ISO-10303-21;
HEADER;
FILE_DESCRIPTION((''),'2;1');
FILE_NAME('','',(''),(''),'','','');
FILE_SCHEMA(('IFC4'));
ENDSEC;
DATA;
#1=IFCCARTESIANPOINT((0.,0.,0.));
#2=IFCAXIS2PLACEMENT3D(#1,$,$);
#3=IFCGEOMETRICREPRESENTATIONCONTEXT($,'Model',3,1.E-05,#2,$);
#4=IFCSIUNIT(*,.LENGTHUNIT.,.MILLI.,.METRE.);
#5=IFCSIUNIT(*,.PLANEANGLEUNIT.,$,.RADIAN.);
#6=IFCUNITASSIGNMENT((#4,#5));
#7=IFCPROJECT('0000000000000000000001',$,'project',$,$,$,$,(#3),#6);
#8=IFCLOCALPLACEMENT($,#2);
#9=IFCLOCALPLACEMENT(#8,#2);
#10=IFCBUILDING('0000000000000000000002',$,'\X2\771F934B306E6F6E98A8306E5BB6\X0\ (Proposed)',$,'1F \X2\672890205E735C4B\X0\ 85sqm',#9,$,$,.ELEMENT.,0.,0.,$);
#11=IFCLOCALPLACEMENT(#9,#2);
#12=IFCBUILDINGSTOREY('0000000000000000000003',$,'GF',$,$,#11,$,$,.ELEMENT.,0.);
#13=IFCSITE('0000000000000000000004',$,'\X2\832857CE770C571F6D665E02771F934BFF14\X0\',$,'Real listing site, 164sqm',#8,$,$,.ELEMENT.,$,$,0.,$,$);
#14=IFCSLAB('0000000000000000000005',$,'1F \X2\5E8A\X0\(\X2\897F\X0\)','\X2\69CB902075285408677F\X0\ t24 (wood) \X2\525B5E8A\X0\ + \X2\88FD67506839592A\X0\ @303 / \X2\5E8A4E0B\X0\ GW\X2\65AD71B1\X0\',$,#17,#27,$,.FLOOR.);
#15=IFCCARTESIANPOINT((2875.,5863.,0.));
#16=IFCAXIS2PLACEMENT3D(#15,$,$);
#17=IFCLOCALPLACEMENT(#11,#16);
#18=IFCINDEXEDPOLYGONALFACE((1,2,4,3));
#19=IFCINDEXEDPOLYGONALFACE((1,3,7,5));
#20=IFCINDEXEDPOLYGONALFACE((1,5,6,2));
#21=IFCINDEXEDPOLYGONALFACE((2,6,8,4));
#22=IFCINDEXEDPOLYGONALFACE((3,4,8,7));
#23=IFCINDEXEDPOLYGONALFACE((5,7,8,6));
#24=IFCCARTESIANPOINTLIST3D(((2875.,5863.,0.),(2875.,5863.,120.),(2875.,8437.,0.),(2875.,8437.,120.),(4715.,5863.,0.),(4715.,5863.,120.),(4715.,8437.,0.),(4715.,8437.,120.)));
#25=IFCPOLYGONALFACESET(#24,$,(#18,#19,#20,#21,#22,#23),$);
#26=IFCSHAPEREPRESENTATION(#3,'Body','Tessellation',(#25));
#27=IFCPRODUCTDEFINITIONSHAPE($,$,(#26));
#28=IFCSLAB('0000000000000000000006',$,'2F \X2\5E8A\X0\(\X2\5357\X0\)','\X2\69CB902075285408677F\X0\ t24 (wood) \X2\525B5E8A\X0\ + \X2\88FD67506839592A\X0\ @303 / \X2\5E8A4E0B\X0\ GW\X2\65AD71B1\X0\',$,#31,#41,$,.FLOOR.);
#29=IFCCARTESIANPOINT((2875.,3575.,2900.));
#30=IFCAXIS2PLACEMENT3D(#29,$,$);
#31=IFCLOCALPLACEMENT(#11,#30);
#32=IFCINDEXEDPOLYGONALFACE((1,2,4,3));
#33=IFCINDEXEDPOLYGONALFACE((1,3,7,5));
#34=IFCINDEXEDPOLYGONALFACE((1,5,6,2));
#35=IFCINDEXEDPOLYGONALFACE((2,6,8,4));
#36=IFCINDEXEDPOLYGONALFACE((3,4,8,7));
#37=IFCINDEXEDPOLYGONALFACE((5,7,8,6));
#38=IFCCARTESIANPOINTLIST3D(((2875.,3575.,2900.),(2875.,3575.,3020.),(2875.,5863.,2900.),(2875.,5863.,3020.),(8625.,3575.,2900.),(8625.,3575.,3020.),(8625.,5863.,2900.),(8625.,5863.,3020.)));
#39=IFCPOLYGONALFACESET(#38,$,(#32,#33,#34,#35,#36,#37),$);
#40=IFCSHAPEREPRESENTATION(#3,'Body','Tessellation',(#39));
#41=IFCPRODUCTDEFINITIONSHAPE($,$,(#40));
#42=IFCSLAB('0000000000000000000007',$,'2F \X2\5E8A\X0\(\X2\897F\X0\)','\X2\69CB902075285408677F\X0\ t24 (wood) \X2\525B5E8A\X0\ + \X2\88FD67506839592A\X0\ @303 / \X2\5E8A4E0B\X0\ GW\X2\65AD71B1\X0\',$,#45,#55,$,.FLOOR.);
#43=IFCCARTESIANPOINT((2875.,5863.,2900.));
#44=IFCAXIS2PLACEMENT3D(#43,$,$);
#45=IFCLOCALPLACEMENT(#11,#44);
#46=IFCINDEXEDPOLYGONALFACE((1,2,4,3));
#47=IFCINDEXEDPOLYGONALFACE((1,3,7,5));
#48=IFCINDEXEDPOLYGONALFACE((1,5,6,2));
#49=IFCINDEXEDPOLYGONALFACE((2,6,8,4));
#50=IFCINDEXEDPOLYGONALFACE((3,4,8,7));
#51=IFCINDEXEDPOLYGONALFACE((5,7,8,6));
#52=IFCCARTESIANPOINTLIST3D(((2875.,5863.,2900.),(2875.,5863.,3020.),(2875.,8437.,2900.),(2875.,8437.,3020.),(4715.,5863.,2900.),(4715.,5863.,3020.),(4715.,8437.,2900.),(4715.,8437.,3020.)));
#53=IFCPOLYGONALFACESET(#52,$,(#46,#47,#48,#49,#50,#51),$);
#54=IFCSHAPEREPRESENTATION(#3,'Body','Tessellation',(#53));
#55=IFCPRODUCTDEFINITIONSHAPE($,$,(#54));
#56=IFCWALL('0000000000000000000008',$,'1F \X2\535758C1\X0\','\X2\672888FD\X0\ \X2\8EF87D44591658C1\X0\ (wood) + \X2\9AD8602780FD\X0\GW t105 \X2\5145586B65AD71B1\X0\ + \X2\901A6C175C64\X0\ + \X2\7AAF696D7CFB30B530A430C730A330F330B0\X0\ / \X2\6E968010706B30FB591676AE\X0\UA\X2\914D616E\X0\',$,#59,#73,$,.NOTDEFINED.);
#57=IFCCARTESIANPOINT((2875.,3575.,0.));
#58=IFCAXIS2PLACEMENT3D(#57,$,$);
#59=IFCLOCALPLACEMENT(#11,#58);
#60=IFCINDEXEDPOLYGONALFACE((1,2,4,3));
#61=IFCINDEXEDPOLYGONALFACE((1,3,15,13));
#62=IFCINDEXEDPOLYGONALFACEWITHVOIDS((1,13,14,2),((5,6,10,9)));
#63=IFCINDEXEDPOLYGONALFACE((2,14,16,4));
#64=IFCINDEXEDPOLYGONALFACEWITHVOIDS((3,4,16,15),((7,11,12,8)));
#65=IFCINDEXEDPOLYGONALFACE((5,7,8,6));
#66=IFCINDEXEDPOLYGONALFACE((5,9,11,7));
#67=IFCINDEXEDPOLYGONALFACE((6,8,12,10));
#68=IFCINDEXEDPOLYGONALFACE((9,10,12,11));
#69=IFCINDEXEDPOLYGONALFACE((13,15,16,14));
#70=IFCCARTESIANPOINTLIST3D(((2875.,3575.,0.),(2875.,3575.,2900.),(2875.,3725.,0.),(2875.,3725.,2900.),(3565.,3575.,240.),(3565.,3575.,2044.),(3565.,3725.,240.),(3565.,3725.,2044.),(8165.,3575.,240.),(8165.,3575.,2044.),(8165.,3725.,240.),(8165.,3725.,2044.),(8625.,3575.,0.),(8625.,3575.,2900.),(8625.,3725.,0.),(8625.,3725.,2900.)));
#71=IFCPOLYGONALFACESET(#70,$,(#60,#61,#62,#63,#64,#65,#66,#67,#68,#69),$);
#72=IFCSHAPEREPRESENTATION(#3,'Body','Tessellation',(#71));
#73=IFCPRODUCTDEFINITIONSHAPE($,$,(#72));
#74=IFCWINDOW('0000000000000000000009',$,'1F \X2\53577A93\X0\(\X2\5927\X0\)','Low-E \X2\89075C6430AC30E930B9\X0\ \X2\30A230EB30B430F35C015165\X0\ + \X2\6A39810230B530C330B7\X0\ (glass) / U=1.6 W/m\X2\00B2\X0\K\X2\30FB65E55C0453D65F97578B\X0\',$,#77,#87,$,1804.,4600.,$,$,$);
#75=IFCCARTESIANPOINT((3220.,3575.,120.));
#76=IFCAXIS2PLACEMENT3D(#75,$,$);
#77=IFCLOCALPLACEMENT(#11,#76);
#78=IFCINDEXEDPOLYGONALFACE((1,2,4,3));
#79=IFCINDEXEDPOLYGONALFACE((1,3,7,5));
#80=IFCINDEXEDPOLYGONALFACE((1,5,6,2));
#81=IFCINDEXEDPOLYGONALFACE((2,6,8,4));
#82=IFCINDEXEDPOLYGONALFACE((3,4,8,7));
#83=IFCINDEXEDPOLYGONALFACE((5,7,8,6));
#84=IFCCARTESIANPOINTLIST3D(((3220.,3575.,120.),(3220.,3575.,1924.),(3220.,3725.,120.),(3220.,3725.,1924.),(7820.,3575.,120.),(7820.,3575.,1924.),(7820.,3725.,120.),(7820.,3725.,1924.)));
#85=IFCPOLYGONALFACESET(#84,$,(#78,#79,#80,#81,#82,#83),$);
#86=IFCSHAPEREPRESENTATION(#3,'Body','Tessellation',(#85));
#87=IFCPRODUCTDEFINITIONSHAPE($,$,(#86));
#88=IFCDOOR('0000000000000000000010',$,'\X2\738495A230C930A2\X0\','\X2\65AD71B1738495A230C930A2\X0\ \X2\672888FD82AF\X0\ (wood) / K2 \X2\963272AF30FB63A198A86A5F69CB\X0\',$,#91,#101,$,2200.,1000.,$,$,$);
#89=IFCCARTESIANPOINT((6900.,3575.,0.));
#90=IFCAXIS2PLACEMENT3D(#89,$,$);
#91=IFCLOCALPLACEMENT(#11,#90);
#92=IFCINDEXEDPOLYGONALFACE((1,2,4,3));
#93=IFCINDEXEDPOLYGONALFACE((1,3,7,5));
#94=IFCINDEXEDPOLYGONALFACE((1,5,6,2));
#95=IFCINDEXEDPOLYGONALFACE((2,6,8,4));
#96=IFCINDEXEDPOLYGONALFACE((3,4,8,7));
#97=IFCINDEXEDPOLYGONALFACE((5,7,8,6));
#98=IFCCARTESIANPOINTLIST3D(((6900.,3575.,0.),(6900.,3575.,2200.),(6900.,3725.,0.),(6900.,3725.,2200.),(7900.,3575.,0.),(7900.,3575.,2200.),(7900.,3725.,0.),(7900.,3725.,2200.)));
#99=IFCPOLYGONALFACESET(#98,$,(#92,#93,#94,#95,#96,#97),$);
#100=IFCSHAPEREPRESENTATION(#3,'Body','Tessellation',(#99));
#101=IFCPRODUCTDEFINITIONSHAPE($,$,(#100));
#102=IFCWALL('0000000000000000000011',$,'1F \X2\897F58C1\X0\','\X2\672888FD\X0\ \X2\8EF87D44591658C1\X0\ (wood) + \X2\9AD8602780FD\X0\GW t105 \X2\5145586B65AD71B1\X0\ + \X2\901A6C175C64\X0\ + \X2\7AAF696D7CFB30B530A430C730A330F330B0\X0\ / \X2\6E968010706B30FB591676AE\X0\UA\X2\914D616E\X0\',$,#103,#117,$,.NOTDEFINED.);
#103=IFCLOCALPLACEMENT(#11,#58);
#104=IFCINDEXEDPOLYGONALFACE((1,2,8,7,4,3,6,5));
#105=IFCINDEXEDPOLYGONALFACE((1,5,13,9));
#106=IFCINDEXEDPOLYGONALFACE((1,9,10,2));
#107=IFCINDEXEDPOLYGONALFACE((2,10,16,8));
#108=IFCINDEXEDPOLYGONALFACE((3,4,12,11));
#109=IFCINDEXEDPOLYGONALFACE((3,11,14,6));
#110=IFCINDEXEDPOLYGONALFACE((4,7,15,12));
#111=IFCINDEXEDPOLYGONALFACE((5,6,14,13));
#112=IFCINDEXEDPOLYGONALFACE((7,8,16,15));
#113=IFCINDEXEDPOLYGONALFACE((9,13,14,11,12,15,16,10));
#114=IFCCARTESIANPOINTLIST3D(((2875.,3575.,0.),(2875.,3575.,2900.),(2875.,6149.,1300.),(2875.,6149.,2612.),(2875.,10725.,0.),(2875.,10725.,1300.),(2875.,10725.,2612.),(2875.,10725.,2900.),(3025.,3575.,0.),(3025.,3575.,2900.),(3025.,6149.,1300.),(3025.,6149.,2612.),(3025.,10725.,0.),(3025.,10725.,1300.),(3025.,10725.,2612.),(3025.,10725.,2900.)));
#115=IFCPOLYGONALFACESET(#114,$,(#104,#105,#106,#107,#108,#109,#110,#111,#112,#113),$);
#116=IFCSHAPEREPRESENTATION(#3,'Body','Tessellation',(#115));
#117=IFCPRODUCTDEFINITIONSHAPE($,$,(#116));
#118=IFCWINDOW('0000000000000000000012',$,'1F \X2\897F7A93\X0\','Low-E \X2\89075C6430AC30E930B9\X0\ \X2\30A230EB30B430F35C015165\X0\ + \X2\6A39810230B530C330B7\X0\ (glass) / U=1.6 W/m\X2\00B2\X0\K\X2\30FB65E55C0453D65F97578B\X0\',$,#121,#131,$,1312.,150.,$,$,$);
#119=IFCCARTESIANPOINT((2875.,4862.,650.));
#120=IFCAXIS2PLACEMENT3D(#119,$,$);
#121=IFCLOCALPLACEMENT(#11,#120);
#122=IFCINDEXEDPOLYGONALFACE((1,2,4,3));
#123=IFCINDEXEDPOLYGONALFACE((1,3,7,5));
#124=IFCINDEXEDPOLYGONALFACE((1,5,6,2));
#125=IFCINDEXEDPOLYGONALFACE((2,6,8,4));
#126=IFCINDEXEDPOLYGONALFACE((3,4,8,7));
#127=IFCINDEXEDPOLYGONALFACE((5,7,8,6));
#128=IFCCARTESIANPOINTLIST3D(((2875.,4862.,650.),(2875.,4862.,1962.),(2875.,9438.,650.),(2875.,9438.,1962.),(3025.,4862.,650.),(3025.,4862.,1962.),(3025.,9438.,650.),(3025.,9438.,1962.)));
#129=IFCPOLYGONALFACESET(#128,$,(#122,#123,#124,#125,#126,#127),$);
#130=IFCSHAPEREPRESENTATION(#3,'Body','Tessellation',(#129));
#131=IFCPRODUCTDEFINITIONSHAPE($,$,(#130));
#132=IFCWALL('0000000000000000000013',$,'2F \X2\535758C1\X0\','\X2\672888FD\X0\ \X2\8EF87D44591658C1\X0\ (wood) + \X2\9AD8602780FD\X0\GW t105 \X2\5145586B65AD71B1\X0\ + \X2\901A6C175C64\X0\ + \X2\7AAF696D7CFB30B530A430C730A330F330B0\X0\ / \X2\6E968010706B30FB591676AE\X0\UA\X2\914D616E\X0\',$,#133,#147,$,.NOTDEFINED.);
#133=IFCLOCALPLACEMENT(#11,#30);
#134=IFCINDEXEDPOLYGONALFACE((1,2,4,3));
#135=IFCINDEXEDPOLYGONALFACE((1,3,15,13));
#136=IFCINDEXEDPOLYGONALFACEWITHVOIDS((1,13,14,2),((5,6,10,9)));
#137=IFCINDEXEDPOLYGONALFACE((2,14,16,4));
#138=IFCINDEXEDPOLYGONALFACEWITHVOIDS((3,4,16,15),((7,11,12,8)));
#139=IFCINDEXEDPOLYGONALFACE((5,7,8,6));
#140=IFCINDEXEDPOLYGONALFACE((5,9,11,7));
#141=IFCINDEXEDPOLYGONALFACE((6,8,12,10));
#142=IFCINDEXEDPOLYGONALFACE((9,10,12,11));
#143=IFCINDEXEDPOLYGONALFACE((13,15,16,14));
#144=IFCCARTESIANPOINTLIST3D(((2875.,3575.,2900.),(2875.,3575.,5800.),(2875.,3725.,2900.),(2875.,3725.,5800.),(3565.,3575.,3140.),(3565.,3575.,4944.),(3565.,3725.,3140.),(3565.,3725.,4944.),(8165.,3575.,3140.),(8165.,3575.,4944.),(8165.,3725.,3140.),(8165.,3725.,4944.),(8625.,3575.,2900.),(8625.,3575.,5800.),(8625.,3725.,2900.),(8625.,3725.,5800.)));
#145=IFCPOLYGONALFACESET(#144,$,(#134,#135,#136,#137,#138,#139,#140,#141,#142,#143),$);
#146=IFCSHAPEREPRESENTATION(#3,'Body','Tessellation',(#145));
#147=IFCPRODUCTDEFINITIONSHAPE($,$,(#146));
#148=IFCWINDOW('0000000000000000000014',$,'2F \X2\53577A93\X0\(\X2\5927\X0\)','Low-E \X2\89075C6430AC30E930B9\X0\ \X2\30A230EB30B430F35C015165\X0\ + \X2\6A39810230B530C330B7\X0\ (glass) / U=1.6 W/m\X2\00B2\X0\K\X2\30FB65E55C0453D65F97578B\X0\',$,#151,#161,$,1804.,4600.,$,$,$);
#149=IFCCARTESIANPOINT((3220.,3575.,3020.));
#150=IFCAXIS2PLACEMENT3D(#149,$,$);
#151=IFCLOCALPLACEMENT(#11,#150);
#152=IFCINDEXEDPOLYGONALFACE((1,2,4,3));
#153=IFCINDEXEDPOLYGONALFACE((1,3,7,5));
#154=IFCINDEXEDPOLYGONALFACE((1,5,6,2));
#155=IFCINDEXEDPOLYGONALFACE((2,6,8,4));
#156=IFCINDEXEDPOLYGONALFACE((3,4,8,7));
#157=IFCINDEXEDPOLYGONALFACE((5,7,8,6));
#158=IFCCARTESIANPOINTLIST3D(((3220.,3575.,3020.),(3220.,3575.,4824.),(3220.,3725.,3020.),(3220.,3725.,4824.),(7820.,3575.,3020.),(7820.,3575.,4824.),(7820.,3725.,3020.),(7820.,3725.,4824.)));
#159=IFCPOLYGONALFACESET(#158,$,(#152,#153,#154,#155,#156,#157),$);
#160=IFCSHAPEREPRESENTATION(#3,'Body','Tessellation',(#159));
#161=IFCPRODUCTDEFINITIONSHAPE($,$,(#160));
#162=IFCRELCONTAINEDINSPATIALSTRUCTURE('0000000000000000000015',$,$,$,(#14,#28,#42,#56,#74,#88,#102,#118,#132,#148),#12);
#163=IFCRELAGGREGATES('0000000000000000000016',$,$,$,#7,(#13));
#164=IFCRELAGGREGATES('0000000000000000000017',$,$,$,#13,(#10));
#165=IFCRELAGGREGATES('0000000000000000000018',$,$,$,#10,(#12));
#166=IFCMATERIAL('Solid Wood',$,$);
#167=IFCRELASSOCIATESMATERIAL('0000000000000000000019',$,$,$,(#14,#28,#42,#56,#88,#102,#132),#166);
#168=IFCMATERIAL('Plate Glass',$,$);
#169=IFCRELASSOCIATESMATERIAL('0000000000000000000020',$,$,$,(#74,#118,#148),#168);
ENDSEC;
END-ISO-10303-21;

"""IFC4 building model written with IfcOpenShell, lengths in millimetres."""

from ifc_helpers import new_model, si_unit, frame, frame_2d, origin, place, context, project, spatial, rectangle, extrude, material, element, fill, save


model = new_model("IFC4")

# Units and contexts
model_context = context("Model", 3, precision=1e-05, world=origin())
ifc_project = project(units=[si_unit("LENGTHUNIT", "METRE", prefix="MILLI"), si_unit("PLANEANGLEUNIT", "RADIAN")], contexts=[model_context])

# Site, building, storey
site_placement = place(None, origin())
site = spatial("IfcSite", under=ifc_project, at=site_placement, Name="茨城県土浦市真鍋４", ObjectType="Real listing site, 164sqm", CompositionType="ELEMENT", RefElevation=0.0)
building_placement = place(site_placement, origin())
building = spatial("IfcBuilding", under=site, at=building_placement, Name="真鍋の潮風の家 (Proposed)", ObjectType="1F 木造平屋 85sqm", CompositionType="ELEMENT", ElevationOfRefHeight=0.0, ElevationOfTerrain=0.0)
storey_placement = place(building_placement, origin())
storey = spatial("IfcBuildingStorey", under=building, at=storey_placement, Name="GF", CompositionType="ELEMENT", Elevation=0.0)

# Slabs
ifc_material_1 = material(Name="Solid Wood")
slab_1_placement = place(storey_placement, frame((2875.0, 5863.0, 0.0)))
element("IfcSlab", 1, at=slab_1_placement, inside=storey, material=ifc_material_1, Name="1F 床(西)", Description="構造用合板 t24 (wood) 剛床 + 製材根太 @303 / 床下 GW断熱", PredefinedType="FLOOR", context=model_context, shape_type="SweptSolid", body=[
    extrude(rectangle(XDim=1840.0, YDim=2574.0, at=frame_2d((920.0, 1287.0))), frame((2875.0, 5863.0, 0.0)), (0.0, 0.0, 1.0), 120.0),
])
slab_2_placement = place(storey_placement, frame((2875.0, 3575.0, 2900.0)))
element("IfcSlab", 2, at=slab_2_placement, inside=storey, material=ifc_material_1, Name="2F 床(南)", Description="構造用合板 t24 (wood) 剛床 + 製材根太 @303 / 床下 GW断熱", PredefinedType="FLOOR", context=model_context, shape_type="SweptSolid", body=[
    extrude(rectangle(XDim=5750.0, YDim=2288.0, at=frame_2d((2875.0, 1144.0))), frame((2875.0, 3575.0, 2900.0)), (0.0, 0.0, 1.0), 120.0),
])
slab_3_placement = place(storey_placement, frame((2875.0, 5863.0, 2900.0)))
element("IfcSlab", 3, at=slab_3_placement, inside=storey, material=ifc_material_1, Name="2F 床(西)", Description="構造用合板 t24 (wood) 剛床 + 製材根太 @303 / 床下 GW断熱", PredefinedType="FLOOR", context=model_context, shape_type="SweptSolid", body=[
    extrude(rectangle(XDim=1840.0, YDim=2574.0, at=frame_2d((920.0, 1287.0))), frame((2875.0, 5863.0, 2900.0)), (0.0, 0.0, 1.0), 120.0),
])

# Wall, openings, window, door
wall_1_placement = place(storey_placement, frame((2875.0, 3575.0, 0.0)))
wall_1 = element("IfcWall", 4, at=wall_1_placement, inside=storey, material=ifc_material_1, Name="1F 南壁", Description="木製 軸組外壁 (wood) + 高性能GW t105 充填断熱 + 通気層 + 窯業系サイディング / 準耐火・外皮UA配慮", PredefinedType="NOTDEFINED", context=model_context, shape_type="SweptSolid", body=[
    extrude(rectangle(XDim=5750.0, YDim=150.0, at=frame_2d((2875.0, 75.0))), frame((2875.0, 3575.0, 0.0)), (0.0, 0.0, 1.0), 2900.0),
])
opening_1_placement = place(storey_placement, frame((3220.0, 3575.0, 120.0)))
opening_1 = element("IfcOpeningElement", 5, at=opening_1_placement, cuts=wall_1, PredefinedType="NOTDEFINED", context=model_context, shape_type="SweptSolid", body=[
    extrude(rectangle(XDim=4600.0, YDim=150.0, at=frame_2d((2300.0, 75.0))), frame((3220.0, 3575.0, 120.0)), (0.0, 0.0, 1.0), 1804.0),
])
opening_2_placement = place(storey_placement, frame((6900.0, 3575.0, 0.0)))
opening_2 = element("IfcOpeningElement", 6, at=opening_2_placement, cuts=wall_1, PredefinedType="NOTDEFINED", context=model_context, shape_type="SweptSolid", body=[
    extrude(rectangle(XDim=1000.0, YDim=150.0, at=frame_2d((500.0, 75.0))), frame((6900.0, 3575.0, 0.0)), (0.0, 0.0, 1.0), 2200.0),
])
ifc_material_2 = material(Name="Plate Glass")
window_1_placement = place(storey_placement, frame((3220.0, 3575.0, 120.0)))
window_1 = element("IfcWindow", 7, at=window_1_placement, inside=storey, material=ifc_material_2, Name="1F 南窓(大)", Description="Low-E 複層ガラス アルゴン封入 + 樹脂サッシ (glass) / U=1.6 W/m²K・日射取得型", OverallHeight=1804.0, OverallWidth=4600.0, context=model_context, shape_type="SweptSolid", body=[
    extrude(rectangle(XDim=4600.0, YDim=150.0, at=frame_2d((2300.0, 75.0))), frame((3220.0, 3575.0, 120.0)), (0.0, 0.0, 1.0), 1804.0),
])
fill(opening_1, window_1)
door_placement = place(storey_placement, frame((6900.0, 3575.0, 0.0)))
door = element("IfcDoor", 8, at=door_placement, inside=storey, material=ifc_material_1, Name="玄関ドア", Description="断熱玄関ドア 木製芯 (wood) / K2 防犯・採風機構", OverallHeight=2200.0, OverallWidth=1000.0, context=model_context, shape_type="SweptSolid", body=[
    extrude(rectangle(XDim=1000.0, YDim=150.0, at=frame_2d((500.0, 75.0))), frame((6900.0, 3575.0, 0.0)), (0.0, 0.0, 1.0), 2200.0),
])
fill(opening_2, door)

# Walls, openings, windows
wall_2_placement = place(storey_placement, frame((2875.0, 3575.0, 0.0)))
wall_2 = element("IfcWall", 9, at=wall_2_placement, inside=storey, material=ifc_material_1, Name="1F 西壁", Description="木製 軸組外壁 (wood) + 高性能GW t105 充填断熱 + 通気層 + 窯業系サイディング / 準耐火・外皮UA配慮", PredefinedType="NOTDEFINED", context=model_context, shape_type="SweptSolid", body=[
    extrude(rectangle(XDim=150.0, YDim=7150.0, at=frame_2d((75.0, 3575.0))), frame((2875.0, 3575.0, 0.0)), (0.0, 0.0, 1.0), 2900.0),
])
opening_3_placement = place(storey_placement, frame((2875.0, 4862.0, 650.0)))
opening_3 = element("IfcOpeningElement", 10, at=opening_3_placement, cuts=wall_2, PredefinedType="NOTDEFINED", context=model_context, shape_type="SweptSolid", body=[
    extrude(rectangle(XDim=150.0, YDim=4576.0, at=frame_2d((75.0, 2288.0))), frame((2875.0, 4862.0, 650.0)), (0.0, 0.0, 1.0), 1312.0),
])
window_2_placement = place(storey_placement, frame((2875.0, 4862.0, 650.0)))
window_2 = element("IfcWindow", 11, at=window_2_placement, inside=storey, material=ifc_material_2, Name="1F 西窓", Description="Low-E 複層ガラス アルゴン封入 + 樹脂サッシ (glass) / U=1.6 W/m²K・日射取得型", OverallHeight=1312.0, OverallWidth=150.0, context=model_context, shape_type="SweptSolid", body=[
    extrude(rectangle(XDim=150.0, YDim=4576.0, at=frame_2d((75.0, 2288.0))), frame((2875.0, 4862.0, 650.0)), (0.0, 0.0, 1.0), 1312.0),
])
fill(opening_3, window_2)
wall_3_placement = place(storey_placement, frame((2875.0, 3575.0, 2900.0)))
wall_3 = element("IfcWall", 12, at=wall_3_placement, inside=storey, material=ifc_material_1, Name="2F 南壁", Description="木製 軸組外壁 (wood) + 高性能GW t105 充填断熱 + 通気層 + 窯業系サイディング / 準耐火・外皮UA配慮", PredefinedType="NOTDEFINED", context=model_context, shape_type="SweptSolid", body=[
    extrude(rectangle(XDim=5750.0, YDim=150.0, at=frame_2d((2875.0, 75.0))), frame((2875.0, 3575.0, 2900.0)), (0.0, 0.0, 1.0), 2900.0),
])
opening_4_placement = place(storey_placement, frame((3220.0, 3575.0, 3020.0)))
opening_4 = element("IfcOpeningElement", 13, at=opening_4_placement, cuts=wall_3, PredefinedType="NOTDEFINED", context=model_context, shape_type="SweptSolid", body=[
    extrude(rectangle(XDim=4600.0, YDim=150.0, at=frame_2d((2300.0, 75.0))), frame((3220.0, 3575.0, 3020.0)), (0.0, 0.0, 1.0), 1804.0),
])
window_3_placement = place(storey_placement, frame((3220.0, 3575.0, 3020.0)))
window_3 = element("IfcWindow", 14, at=window_3_placement, inside=storey, material=ifc_material_2, Name="2F 南窓(大)", Description="Low-E 複層ガラス アルゴン封入 + 樹脂サッシ (glass) / U=1.6 W/m²K・日射取得型", OverallHeight=1804.0, OverallWidth=4600.0, context=model_context, shape_type="SweptSolid", body=[
    extrude(rectangle(XDim=4600.0, YDim=150.0, at=frame_2d((2300.0, 75.0))), frame((3220.0, 3575.0, 3020.0)), (0.0, 0.0, 1.0), 1804.0),
])
fill(opening_4, window_3)

save(model, "model.ifc")
